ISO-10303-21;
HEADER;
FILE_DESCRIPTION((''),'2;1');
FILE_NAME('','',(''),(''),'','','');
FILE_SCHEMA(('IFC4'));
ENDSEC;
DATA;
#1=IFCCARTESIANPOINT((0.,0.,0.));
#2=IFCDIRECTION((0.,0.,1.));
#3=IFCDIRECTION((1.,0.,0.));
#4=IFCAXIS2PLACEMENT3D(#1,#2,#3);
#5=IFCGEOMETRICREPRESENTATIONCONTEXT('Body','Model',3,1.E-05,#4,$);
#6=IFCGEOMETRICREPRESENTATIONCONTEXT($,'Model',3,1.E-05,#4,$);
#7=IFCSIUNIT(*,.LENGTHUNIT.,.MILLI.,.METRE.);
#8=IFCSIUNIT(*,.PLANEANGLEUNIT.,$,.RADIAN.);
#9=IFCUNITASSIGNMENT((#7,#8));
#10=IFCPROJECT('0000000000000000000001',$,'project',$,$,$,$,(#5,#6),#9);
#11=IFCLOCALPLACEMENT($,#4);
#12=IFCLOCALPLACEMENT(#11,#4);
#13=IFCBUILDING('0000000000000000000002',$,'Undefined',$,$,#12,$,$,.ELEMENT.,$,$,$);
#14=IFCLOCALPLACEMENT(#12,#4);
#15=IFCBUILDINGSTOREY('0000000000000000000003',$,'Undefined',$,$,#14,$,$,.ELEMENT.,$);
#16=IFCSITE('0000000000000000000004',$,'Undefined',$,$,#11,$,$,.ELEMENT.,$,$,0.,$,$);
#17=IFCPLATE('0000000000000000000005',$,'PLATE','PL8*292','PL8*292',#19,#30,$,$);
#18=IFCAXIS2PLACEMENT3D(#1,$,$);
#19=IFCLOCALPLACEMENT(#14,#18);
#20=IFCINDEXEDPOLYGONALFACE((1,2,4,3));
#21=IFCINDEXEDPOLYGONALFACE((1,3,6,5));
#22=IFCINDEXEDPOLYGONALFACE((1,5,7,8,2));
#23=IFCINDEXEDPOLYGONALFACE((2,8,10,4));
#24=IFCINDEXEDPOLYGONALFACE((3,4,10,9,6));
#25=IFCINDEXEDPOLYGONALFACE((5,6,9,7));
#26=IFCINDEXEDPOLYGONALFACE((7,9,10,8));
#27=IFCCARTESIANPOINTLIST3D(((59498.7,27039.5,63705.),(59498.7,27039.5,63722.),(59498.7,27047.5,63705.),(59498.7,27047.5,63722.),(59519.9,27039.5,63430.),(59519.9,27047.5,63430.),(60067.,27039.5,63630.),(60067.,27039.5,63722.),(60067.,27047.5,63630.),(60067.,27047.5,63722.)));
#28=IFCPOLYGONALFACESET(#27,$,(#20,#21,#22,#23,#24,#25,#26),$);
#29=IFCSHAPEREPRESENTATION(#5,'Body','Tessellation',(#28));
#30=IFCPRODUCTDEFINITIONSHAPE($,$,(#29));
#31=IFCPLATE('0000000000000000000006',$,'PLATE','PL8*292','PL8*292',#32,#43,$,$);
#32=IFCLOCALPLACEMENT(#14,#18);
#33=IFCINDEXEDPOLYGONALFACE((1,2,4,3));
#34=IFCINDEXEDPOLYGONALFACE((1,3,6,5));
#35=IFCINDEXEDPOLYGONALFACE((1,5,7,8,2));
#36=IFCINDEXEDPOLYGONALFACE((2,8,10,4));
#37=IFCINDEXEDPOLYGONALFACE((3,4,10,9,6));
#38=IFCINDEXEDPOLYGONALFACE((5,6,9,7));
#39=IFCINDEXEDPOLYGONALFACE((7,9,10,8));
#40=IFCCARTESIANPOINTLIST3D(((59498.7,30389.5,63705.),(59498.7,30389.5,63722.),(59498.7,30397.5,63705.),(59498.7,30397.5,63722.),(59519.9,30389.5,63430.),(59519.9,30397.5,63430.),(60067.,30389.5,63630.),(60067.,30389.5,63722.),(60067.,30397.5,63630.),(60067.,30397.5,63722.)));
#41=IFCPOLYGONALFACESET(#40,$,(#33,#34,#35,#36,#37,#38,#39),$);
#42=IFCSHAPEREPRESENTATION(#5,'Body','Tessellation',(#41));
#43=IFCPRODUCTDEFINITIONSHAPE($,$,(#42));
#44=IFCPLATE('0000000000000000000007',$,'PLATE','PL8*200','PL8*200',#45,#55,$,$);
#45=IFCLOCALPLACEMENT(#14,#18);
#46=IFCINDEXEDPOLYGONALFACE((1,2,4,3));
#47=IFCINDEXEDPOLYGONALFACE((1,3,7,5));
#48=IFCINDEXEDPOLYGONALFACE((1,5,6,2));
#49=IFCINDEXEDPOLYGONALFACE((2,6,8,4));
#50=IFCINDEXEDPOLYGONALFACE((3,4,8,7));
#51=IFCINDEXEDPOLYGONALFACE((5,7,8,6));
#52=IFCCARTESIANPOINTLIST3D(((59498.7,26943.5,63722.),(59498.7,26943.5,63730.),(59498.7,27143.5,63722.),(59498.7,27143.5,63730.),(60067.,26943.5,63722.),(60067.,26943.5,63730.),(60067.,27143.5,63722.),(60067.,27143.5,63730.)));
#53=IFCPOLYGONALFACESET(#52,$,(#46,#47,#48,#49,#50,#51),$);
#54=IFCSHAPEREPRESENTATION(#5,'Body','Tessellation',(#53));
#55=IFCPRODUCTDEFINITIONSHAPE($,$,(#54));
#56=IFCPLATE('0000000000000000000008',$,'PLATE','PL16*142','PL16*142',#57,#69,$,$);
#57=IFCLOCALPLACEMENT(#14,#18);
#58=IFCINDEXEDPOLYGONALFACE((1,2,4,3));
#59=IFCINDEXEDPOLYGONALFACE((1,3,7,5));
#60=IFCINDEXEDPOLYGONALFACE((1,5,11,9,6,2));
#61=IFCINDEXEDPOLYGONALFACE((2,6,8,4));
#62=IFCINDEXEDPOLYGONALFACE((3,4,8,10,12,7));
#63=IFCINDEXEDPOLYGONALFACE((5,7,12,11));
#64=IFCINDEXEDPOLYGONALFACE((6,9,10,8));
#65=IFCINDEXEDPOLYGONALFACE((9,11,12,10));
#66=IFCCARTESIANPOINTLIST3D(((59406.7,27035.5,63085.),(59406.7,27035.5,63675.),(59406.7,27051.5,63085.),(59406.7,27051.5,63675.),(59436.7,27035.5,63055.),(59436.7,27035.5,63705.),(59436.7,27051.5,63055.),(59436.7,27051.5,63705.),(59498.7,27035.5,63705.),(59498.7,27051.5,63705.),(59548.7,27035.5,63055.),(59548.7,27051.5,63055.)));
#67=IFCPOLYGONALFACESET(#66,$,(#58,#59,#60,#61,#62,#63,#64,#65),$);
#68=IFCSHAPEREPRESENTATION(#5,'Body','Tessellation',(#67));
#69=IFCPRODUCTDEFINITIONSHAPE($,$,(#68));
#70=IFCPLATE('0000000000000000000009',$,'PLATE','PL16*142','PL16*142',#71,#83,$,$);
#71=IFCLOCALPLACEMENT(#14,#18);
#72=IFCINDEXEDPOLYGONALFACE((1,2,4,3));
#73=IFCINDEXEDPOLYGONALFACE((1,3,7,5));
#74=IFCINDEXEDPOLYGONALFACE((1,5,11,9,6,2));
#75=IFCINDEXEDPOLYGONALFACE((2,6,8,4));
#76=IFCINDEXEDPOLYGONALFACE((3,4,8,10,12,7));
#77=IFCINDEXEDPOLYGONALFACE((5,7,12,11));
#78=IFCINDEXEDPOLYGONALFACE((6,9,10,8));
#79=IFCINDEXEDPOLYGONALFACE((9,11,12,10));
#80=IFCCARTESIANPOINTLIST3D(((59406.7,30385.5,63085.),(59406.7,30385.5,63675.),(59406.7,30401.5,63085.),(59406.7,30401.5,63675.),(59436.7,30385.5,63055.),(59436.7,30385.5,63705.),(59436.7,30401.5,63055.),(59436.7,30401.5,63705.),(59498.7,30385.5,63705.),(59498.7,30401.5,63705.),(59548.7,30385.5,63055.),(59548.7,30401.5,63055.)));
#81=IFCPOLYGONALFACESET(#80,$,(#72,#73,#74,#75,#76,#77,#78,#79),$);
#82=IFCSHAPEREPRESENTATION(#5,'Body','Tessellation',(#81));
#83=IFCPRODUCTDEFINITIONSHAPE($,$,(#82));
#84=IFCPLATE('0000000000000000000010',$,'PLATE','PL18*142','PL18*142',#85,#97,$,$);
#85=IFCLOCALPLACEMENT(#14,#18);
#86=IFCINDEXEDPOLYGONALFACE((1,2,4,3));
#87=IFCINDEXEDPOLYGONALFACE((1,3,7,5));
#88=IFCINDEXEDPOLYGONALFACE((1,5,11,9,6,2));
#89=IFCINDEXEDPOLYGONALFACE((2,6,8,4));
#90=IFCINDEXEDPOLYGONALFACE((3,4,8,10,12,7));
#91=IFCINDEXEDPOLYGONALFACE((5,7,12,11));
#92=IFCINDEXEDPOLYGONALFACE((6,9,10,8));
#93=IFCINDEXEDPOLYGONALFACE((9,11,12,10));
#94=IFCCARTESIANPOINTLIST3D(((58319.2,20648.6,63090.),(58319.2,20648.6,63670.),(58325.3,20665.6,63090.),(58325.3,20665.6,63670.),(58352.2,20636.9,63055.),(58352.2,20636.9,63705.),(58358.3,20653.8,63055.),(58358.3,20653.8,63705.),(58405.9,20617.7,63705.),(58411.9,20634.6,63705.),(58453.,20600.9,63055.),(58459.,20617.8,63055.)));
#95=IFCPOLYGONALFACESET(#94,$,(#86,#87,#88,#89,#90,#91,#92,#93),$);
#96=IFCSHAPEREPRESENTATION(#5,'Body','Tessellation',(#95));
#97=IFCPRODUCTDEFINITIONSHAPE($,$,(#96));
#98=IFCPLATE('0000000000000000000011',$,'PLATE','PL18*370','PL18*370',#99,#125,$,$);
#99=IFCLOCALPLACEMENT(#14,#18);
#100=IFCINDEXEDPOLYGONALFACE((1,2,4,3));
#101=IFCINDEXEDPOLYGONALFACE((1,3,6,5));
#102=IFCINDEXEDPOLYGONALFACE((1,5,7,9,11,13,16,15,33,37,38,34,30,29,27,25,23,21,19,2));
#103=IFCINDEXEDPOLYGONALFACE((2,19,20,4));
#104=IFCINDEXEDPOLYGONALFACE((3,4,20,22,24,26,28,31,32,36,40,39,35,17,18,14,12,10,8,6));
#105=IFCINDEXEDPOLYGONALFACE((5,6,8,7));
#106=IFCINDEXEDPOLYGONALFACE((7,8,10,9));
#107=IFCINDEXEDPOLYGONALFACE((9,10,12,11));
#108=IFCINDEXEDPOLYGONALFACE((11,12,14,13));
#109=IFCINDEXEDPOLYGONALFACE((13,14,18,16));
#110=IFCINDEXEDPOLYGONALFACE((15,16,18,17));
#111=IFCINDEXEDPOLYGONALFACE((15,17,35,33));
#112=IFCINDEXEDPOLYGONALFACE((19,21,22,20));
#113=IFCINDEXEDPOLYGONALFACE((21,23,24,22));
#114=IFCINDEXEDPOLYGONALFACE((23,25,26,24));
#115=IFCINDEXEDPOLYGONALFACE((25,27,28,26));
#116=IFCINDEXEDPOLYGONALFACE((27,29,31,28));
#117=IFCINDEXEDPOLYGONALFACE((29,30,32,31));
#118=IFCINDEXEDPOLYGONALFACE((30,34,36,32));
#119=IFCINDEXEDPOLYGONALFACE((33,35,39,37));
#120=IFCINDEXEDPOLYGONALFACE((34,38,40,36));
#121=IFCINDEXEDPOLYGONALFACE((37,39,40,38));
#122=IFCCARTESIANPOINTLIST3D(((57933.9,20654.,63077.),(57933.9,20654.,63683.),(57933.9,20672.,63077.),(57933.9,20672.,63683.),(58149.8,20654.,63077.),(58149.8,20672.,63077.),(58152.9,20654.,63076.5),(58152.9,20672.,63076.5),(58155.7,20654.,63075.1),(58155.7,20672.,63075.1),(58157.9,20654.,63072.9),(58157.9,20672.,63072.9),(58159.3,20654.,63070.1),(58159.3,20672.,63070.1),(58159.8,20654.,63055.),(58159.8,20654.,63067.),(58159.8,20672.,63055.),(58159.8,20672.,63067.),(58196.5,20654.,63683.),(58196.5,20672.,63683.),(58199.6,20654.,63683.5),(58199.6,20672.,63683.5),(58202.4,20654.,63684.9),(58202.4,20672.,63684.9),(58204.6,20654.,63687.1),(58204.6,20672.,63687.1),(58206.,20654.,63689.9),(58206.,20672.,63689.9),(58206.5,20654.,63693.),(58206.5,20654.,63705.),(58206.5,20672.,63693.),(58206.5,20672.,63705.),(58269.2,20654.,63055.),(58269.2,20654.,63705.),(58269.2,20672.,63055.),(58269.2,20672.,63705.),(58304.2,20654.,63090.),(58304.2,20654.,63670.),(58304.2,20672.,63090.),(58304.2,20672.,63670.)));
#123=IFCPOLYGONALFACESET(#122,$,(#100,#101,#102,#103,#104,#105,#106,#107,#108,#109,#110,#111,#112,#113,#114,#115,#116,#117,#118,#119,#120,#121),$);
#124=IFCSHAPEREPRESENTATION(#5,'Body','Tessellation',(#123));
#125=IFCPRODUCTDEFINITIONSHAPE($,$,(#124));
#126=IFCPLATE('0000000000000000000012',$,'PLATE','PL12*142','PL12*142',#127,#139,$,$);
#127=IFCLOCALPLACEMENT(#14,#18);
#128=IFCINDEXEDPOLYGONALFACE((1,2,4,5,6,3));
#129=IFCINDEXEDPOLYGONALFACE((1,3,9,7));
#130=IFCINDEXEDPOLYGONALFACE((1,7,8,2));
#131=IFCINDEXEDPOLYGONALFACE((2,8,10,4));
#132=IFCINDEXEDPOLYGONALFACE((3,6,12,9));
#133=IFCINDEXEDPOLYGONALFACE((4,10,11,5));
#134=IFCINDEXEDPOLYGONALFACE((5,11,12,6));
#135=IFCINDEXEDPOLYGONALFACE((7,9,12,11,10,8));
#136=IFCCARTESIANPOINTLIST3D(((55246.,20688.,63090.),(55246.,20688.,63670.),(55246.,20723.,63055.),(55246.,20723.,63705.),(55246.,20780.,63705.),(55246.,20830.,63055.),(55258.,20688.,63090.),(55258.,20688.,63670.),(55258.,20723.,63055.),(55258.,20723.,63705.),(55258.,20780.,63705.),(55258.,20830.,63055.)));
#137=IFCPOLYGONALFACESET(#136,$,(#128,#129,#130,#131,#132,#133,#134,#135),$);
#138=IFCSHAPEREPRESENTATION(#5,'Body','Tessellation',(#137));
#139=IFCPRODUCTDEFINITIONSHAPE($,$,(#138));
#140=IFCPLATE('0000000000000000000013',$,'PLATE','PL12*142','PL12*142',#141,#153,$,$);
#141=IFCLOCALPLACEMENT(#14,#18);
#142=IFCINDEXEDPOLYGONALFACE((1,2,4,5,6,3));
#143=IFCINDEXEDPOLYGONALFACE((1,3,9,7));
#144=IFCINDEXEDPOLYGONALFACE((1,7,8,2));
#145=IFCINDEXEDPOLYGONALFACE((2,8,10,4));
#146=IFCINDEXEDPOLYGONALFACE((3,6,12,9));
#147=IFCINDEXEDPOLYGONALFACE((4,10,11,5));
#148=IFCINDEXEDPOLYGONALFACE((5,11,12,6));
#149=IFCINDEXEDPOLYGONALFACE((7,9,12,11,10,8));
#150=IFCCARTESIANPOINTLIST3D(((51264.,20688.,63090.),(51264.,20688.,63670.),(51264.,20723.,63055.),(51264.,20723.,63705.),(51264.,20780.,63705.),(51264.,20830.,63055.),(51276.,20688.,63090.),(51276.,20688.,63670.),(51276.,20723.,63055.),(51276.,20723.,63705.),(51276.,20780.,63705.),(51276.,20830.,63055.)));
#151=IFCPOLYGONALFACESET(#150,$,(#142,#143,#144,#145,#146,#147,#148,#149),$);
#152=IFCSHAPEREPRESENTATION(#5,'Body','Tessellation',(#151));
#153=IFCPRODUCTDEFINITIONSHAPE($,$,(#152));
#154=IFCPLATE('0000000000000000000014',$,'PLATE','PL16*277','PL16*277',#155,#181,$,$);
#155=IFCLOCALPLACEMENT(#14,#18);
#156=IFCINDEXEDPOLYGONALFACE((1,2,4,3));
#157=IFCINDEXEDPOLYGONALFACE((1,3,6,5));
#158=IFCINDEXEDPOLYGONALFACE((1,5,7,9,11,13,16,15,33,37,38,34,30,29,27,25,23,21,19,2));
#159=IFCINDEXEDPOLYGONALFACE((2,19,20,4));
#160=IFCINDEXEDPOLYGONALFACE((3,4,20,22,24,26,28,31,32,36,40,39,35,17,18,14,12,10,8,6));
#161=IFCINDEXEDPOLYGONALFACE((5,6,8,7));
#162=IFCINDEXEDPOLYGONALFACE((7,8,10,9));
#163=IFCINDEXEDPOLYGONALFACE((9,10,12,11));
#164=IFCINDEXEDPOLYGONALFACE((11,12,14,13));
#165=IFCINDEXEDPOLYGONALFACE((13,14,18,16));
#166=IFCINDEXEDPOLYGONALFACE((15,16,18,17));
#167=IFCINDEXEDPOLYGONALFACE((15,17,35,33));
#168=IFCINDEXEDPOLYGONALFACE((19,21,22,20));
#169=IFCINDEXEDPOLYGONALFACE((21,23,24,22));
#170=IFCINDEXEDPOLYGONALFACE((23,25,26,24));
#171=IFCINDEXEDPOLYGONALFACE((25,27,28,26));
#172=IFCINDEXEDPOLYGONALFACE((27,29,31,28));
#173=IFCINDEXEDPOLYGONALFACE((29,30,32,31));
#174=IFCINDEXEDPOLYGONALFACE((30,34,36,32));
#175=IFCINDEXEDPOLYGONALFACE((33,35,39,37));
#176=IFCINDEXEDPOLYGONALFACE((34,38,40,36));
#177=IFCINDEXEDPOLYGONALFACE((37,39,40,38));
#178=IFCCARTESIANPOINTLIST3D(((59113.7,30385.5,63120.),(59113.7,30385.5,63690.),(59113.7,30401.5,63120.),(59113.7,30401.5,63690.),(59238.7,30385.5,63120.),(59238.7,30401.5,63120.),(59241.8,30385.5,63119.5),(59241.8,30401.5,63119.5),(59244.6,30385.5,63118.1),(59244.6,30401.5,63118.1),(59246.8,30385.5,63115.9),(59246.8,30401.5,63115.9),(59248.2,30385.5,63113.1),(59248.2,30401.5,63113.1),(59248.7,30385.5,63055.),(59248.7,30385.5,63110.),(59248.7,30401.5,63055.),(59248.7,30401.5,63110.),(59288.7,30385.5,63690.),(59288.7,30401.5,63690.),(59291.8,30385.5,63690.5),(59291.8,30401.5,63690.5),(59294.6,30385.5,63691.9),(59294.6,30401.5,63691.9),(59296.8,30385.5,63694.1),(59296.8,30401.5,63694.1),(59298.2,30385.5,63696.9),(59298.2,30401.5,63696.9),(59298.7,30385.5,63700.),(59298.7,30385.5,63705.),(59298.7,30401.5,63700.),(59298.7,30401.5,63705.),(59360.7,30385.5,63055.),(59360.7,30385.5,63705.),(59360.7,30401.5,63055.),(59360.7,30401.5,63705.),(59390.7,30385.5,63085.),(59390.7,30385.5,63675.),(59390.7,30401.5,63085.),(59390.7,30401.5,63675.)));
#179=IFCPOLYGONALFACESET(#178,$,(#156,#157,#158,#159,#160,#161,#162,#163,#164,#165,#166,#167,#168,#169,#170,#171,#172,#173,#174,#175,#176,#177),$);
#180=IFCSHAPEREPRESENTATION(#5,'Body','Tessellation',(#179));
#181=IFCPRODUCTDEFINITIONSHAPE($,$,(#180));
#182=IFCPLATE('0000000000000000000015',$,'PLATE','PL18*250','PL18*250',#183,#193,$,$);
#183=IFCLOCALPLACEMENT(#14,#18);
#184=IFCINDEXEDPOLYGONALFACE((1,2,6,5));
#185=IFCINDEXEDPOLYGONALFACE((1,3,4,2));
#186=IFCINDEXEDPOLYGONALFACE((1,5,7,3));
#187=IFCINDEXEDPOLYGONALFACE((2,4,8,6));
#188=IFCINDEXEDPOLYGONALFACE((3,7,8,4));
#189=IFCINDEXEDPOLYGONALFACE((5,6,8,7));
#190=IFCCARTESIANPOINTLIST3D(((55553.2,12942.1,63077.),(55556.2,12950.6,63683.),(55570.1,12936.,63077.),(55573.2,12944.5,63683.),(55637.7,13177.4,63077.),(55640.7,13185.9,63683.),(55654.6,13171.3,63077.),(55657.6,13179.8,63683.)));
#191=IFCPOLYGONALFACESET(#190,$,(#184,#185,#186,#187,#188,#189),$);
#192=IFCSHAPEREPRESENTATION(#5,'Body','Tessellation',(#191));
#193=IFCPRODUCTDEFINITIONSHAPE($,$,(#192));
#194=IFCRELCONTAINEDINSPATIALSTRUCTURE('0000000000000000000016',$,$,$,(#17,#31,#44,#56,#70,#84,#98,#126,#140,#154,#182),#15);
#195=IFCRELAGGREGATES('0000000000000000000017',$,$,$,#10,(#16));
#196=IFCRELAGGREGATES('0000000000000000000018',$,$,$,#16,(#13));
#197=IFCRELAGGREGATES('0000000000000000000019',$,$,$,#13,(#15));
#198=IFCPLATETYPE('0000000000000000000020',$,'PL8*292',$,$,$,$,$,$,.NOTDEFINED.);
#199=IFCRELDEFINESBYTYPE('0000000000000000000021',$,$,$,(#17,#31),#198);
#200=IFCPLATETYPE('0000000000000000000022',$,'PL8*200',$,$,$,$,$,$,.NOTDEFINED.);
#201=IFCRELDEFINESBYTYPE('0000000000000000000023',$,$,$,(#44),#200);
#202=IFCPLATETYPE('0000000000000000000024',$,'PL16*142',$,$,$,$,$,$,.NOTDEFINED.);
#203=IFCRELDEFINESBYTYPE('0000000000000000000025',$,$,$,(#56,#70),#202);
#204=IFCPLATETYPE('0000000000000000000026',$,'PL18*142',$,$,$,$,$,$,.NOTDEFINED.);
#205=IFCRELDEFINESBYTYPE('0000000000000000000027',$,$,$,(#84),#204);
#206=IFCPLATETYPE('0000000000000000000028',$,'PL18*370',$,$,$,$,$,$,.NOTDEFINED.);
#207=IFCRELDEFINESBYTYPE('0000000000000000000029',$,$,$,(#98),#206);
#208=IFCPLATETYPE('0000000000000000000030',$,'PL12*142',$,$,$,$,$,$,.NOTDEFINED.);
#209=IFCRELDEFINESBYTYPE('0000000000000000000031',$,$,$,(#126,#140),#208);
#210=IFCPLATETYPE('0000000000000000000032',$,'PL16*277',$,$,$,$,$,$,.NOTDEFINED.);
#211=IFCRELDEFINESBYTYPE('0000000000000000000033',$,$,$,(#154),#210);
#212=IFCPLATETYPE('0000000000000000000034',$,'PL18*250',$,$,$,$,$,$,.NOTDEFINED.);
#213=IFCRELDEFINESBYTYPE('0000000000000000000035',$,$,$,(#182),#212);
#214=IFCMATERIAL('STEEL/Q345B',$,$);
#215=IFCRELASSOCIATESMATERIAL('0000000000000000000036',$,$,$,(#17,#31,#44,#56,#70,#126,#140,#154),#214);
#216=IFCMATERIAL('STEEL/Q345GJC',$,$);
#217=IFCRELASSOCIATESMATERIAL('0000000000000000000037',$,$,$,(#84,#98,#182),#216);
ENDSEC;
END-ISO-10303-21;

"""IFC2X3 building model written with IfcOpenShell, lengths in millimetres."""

from ifc_helpers import new_model, si_unit, frame, origin_with_axes, place, context, project, spatial, polyline, outline, extrude, material, type_object, element, save


model = new_model("IFC2X3")

# Units and contexts
model_context_1 = context("Model", 3, precision=1e-05, world=origin_with_axes(), identifier="Body")
model_context_2 = context("Model", 3, precision=1e-05, world=origin_with_axes())
ifc_project = project(units=[si_unit("LENGTHUNIT", "METRE", prefix="MILLI"), si_unit("PLANEANGLEUNIT", "RADIAN")], contexts=[model_context_1, model_context_2])

# Site, building, storey
site_placement = place(None, origin_with_axes())
site = spatial("IfcSite", under=ifc_project, at=site_placement, Name="Undefined", CompositionType="ELEMENT", RefElevation=0.0)
building_placement = place(site_placement, origin_with_axes())
building = spatial("IfcBuilding", under=site, at=building_placement, Name="Undefined", CompositionType="ELEMENT")
storey_placement = place(building_placement, origin_with_axes())
storey = spatial("IfcBuildingStorey", under=building, at=storey_placement, Name="Undefined", CompositionType="ELEMENT")

# Shared definitions
ifc_material_1 = material(Name="STEEL/Q345B")
ifc_material_2 = material(Name="STEEL/Q345GJC")

# Plates
plate_type_1 = type_object("IfcPlateType", Name="PL8*292", PredefinedType="NOTDEFINED")
for number, where, z_axis, x_axis, name in (
    (1, (59498.7, 27043.5, 63722.0), (0.0, -1.0, 0.0), (0.0, 0.0, -1.0), "PLATE"),
    (2, (59498.7, 30393.5, 63722.0), (0.0, -1.0, 0.0), (0.0, 0.0, -1.0), "PLATE"),
):
    element("IfcPlate", number, at=place(storey_placement, frame(where, z_axis=z_axis, x_axis=x_axis)), inside=storey, type_object=plate_type_1, material=ifc_material_1, Name=name, Description="PL8*292", ObjectType="PL8*292", context=model_context_1, shape_type="SweptSolid", body=[
        extrude(outline(polyline([(0.0, 0.0), (17.0, 0.0), (292.0, 21.2), (92.0, 568.3), (0.0, 568.3), (0.0, 0.0)])), frame((0.0, 0.0, -4.0), z_axis=(0.0, 0.0, 1.0), x_axis=(1.0, 0.0, 0.0)), (0.0, 0.0, 1.0), 8.0),
    ])
plate_type_2 = type_object("IfcPlateType", Name="PL8*200", PredefinedType="NOTDEFINED")
plate_1_placement = place(storey_placement, frame((60067.0, 27143.5, 63726.0), z_axis=(0.0, 0.0, 1.0), x_axis=(-1.0, 0.0, 0.0)))
element("IfcPlate", 3, at=plate_1_placement, inside=storey, type_object=plate_type_2, material=ifc_material_1, Name="PLATE", Description="PL8*200", ObjectType="PL8*200", context=model_context_1, shape_type="SweptSolid", body=[
    extrude(outline(polyline([(0.0, 0.0), (568.3, 0.0), (568.3, 200.0), (0.0, 200.0), (0.0, 0.0)])), frame((0.0, 0.0, -4.0), z_axis=(0.0, 0.0, 1.0), x_axis=(1.0, 0.0, 0.0)), (0.0, 0.0, 1.0), 8.0),
])
plate_type_3 = type_object("IfcPlateType", Name="PL16*142", PredefinedType="NOTDEFINED")
for number, where, z_axis, x_axis, name in (
    (4, (59406.7, 27043.5, 63055.0), (0.0, -1.0, 0.0), (1.0, 0.0, 0.0), "PLATE"),
    (5, (59406.7, 30393.5, 63055.0), (0.0, -1.0, 0.0), (1.0, 0.0, 0.0), "PLATE"),
):
    element("IfcPlate", number, at=place(storey_placement, frame(where, z_axis=z_axis, x_axis=x_axis)), inside=storey, type_object=plate_type_3, material=ifc_material_1, Name=name, Description="PL16*142", ObjectType="PL16*142", context=model_context_1, shape_type="SweptSolid", body=[
        extrude(outline(polyline([(0.0, 30.0), (30.0, 0.0), (142.0, 0.0), (92.0, 650.0), (30.0, 650.0), (0.0, 620.0), (0.0, 30.0)])), frame((0.0, 0.0, -8.0), z_axis=(0.0, 0.0, 1.0), x_axis=(1.0, 0.0, 0.0)), (0.0, 0.0, 1.0), 16.0),
    ])
plate_type_4 = type_object("IfcPlateType", Name="PL18*142", PredefinedType="NOTDEFINED")
plate_2_placement = place(storey_placement, frame((58322.3, 20657.1, 63705.0), z_axis=(0.336214, 0.941786, 0.0), x_axis=(0.941786, -0.336214, 0.0)))
element("IfcPlate", 6, at=plate_2_placement, inside=storey, type_object=plate_type_4, material=ifc_material_2, Name="PLATE", Description="PL18*142", ObjectType="PL18*142", context=model_context_1, shape_type="SweptSolid", body=[
    extrude(outline(polyline([(0.0, 35.0), (35.0, 0.0), (92.0, 0.0), (142.0, 650.0), (35.0, 650.0), (0.0, 615.0), (0.0, 35.0)])), frame((0.0, 0.0, -9.0), z_axis=(0.0, 0.0, 1.0), x_axis=(1.0, 0.0, 0.0)), (0.0, 0.0, 1.0), 18.0),
])
plate_type_5 = type_object("IfcPlateType", Name="PL18*370", PredefinedType="NOTDEFINED")
plate_3_placement = place(storey_placement, frame((58206.5, 20663.0, 63705.0), z_axis=(0.0, 1.0, 0.0), x_axis=(1.0, 0.0, 0.0)))
element("IfcPlate", 7, at=plate_3_placement, inside=storey, type_object=plate_type_5, material=ifc_material_2, Name="PLATE", Description="PL18*370", ObjectType="PL18*370", context=model_context_1, shape_type="SweptSolid", body=[
    extrude(outline(polyline([(0.0, 0.0), (62.7, 0.0), (97.7, 35.0), (97.7, 615.0), (62.7, 650.0), (-46.7, 650.0), (-46.7, 638.0), (-47.2, 634.9), (-48.6, 632.1), (-50.8, 629.9), (-53.6, 628.5), (-56.7, 628.0), (-272.6, 628.0), (-272.6, 22.0), (-10.0, 22.0), (-6.9, 21.5), (-4.1, 20.1), (-1.9, 17.9), (-0.5, 15.1), (0.0, 12.0), (0.0, 0.0)])), frame((0.0, 0.0, -9.0), z_axis=(0.0, 0.0, 1.0), x_axis=(1.0, 0.0, 0.0)), (0.0, 0.0, 1.0), 18.0),
])
plate_type_6 = type_object("IfcPlateType", Name="PL12*142", PredefinedType="NOTDEFINED")
for number, where, z_axis, x_axis, name in (
    (8, (55252.0, 20830.0, 63055.0), (-1.0, 0.0, 0.0), (0.0, -1.0, 0.0), "PLATE"),
    (9, (51270.0, 20830.0, 63055.0), (-1.0, 0.0, 0.0), (0.0, -1.0, 0.0), "PLATE"),
):
    element("IfcPlate", number, at=place(storey_placement, frame(where, z_axis=z_axis, x_axis=x_axis)), inside=storey, type_object=plate_type_6, material=ifc_material_1, Name=name, Description="PL12*142", ObjectType="PL12*142", context=model_context_1, shape_type="SweptSolid", body=[
        extrude(outline(polyline([(0.0, 0.0), (107.0, 0.0), (142.0, 35.0), (142.0, 615.0), (107.0, 650.0), (50.0, 650.0), (0.0, 0.0)])), frame((0.0, 0.0, -6.0), z_axis=(0.0, 0.0, 1.0), x_axis=(1.0, 0.0, 0.0)), (0.0, 0.0, 1.0), 12.0),
    ])
plate_type_7 = type_object("IfcPlateType", Name="PL16*277", PredefinedType="NOTDEFINED")
plate_4_placement = place(storey_placement, frame((59390.7, 30393.5, 63085.0), z_axis=(0.0, 1.0, 0.0), x_axis=(-0.707107, 0.0, -0.707107)))
element("IfcPlate", 10, at=plate_4_placement, inside=storey, type_object=plate_type_7, material=ifc_material_1, Name="PLATE", Description="PL16*277", ObjectType="PL16*277", context=model_context_1, shape_type="SweptSolid", body=[
    extrude(outline(polyline([(0.0, 0.0), (42.4, 0.0), (121.6, 79.2), (82.7, 118.1), (80.9, 120.6), (79.9, 123.6), (79.9, 126.7), (80.9, 129.7), (82.7, 132.2), (171.1, 220.6), (-231.9, 623.7), (-355.7, 499.9), (-358.2, 498.1), (-361.2, 497.1), (-364.3, 497.1), (-367.3, 498.1), (-369.8, 499.9), (-373.4, 503.5), (-417.2, 459.6), (-417.2, 417.2), (0.0, 0.0)])), frame((0.0, 0.0, -8.0), z_axis=(0.0, 0.0, 1.0), x_axis=(1.0, 0.0, 0.0)), (0.0, 0.0, 1.0), 16.0),
])
plate_type_8 = type_object("IfcPlateType", Name="PL18*250", PredefinedType="NOTDEFINED")
plate_5_placement = place(storey_placement, frame((55649.2, 13182.9, 63683.0), z_axis=(0.941212, -0.337816, 0.0), x_axis=(-0.337816, -0.941212, 0.0)))
element("IfcPlate", 11, at=plate_5_placement, inside=storey, type_object=plate_type_8, material=ifc_material_2, Name="PLATE", Description="PL18*250", ObjectType="PL18*250", context=model_context_1, shape_type="SweptSolid", body=[
    extrude(outline(polyline([(0.0, 0.0), (250.0, 0.0), (259.0, 606.0), (9.0, 606.0), (0.0, 0.0)])), frame((0.0, 0.0, -9.0), z_axis=(0.0, 0.0, 1.0), x_axis=(1.0, 0.0, 0.0)), (0.0, 0.0, 1.0), 18.0),
])

save(model, "model.ifc")
